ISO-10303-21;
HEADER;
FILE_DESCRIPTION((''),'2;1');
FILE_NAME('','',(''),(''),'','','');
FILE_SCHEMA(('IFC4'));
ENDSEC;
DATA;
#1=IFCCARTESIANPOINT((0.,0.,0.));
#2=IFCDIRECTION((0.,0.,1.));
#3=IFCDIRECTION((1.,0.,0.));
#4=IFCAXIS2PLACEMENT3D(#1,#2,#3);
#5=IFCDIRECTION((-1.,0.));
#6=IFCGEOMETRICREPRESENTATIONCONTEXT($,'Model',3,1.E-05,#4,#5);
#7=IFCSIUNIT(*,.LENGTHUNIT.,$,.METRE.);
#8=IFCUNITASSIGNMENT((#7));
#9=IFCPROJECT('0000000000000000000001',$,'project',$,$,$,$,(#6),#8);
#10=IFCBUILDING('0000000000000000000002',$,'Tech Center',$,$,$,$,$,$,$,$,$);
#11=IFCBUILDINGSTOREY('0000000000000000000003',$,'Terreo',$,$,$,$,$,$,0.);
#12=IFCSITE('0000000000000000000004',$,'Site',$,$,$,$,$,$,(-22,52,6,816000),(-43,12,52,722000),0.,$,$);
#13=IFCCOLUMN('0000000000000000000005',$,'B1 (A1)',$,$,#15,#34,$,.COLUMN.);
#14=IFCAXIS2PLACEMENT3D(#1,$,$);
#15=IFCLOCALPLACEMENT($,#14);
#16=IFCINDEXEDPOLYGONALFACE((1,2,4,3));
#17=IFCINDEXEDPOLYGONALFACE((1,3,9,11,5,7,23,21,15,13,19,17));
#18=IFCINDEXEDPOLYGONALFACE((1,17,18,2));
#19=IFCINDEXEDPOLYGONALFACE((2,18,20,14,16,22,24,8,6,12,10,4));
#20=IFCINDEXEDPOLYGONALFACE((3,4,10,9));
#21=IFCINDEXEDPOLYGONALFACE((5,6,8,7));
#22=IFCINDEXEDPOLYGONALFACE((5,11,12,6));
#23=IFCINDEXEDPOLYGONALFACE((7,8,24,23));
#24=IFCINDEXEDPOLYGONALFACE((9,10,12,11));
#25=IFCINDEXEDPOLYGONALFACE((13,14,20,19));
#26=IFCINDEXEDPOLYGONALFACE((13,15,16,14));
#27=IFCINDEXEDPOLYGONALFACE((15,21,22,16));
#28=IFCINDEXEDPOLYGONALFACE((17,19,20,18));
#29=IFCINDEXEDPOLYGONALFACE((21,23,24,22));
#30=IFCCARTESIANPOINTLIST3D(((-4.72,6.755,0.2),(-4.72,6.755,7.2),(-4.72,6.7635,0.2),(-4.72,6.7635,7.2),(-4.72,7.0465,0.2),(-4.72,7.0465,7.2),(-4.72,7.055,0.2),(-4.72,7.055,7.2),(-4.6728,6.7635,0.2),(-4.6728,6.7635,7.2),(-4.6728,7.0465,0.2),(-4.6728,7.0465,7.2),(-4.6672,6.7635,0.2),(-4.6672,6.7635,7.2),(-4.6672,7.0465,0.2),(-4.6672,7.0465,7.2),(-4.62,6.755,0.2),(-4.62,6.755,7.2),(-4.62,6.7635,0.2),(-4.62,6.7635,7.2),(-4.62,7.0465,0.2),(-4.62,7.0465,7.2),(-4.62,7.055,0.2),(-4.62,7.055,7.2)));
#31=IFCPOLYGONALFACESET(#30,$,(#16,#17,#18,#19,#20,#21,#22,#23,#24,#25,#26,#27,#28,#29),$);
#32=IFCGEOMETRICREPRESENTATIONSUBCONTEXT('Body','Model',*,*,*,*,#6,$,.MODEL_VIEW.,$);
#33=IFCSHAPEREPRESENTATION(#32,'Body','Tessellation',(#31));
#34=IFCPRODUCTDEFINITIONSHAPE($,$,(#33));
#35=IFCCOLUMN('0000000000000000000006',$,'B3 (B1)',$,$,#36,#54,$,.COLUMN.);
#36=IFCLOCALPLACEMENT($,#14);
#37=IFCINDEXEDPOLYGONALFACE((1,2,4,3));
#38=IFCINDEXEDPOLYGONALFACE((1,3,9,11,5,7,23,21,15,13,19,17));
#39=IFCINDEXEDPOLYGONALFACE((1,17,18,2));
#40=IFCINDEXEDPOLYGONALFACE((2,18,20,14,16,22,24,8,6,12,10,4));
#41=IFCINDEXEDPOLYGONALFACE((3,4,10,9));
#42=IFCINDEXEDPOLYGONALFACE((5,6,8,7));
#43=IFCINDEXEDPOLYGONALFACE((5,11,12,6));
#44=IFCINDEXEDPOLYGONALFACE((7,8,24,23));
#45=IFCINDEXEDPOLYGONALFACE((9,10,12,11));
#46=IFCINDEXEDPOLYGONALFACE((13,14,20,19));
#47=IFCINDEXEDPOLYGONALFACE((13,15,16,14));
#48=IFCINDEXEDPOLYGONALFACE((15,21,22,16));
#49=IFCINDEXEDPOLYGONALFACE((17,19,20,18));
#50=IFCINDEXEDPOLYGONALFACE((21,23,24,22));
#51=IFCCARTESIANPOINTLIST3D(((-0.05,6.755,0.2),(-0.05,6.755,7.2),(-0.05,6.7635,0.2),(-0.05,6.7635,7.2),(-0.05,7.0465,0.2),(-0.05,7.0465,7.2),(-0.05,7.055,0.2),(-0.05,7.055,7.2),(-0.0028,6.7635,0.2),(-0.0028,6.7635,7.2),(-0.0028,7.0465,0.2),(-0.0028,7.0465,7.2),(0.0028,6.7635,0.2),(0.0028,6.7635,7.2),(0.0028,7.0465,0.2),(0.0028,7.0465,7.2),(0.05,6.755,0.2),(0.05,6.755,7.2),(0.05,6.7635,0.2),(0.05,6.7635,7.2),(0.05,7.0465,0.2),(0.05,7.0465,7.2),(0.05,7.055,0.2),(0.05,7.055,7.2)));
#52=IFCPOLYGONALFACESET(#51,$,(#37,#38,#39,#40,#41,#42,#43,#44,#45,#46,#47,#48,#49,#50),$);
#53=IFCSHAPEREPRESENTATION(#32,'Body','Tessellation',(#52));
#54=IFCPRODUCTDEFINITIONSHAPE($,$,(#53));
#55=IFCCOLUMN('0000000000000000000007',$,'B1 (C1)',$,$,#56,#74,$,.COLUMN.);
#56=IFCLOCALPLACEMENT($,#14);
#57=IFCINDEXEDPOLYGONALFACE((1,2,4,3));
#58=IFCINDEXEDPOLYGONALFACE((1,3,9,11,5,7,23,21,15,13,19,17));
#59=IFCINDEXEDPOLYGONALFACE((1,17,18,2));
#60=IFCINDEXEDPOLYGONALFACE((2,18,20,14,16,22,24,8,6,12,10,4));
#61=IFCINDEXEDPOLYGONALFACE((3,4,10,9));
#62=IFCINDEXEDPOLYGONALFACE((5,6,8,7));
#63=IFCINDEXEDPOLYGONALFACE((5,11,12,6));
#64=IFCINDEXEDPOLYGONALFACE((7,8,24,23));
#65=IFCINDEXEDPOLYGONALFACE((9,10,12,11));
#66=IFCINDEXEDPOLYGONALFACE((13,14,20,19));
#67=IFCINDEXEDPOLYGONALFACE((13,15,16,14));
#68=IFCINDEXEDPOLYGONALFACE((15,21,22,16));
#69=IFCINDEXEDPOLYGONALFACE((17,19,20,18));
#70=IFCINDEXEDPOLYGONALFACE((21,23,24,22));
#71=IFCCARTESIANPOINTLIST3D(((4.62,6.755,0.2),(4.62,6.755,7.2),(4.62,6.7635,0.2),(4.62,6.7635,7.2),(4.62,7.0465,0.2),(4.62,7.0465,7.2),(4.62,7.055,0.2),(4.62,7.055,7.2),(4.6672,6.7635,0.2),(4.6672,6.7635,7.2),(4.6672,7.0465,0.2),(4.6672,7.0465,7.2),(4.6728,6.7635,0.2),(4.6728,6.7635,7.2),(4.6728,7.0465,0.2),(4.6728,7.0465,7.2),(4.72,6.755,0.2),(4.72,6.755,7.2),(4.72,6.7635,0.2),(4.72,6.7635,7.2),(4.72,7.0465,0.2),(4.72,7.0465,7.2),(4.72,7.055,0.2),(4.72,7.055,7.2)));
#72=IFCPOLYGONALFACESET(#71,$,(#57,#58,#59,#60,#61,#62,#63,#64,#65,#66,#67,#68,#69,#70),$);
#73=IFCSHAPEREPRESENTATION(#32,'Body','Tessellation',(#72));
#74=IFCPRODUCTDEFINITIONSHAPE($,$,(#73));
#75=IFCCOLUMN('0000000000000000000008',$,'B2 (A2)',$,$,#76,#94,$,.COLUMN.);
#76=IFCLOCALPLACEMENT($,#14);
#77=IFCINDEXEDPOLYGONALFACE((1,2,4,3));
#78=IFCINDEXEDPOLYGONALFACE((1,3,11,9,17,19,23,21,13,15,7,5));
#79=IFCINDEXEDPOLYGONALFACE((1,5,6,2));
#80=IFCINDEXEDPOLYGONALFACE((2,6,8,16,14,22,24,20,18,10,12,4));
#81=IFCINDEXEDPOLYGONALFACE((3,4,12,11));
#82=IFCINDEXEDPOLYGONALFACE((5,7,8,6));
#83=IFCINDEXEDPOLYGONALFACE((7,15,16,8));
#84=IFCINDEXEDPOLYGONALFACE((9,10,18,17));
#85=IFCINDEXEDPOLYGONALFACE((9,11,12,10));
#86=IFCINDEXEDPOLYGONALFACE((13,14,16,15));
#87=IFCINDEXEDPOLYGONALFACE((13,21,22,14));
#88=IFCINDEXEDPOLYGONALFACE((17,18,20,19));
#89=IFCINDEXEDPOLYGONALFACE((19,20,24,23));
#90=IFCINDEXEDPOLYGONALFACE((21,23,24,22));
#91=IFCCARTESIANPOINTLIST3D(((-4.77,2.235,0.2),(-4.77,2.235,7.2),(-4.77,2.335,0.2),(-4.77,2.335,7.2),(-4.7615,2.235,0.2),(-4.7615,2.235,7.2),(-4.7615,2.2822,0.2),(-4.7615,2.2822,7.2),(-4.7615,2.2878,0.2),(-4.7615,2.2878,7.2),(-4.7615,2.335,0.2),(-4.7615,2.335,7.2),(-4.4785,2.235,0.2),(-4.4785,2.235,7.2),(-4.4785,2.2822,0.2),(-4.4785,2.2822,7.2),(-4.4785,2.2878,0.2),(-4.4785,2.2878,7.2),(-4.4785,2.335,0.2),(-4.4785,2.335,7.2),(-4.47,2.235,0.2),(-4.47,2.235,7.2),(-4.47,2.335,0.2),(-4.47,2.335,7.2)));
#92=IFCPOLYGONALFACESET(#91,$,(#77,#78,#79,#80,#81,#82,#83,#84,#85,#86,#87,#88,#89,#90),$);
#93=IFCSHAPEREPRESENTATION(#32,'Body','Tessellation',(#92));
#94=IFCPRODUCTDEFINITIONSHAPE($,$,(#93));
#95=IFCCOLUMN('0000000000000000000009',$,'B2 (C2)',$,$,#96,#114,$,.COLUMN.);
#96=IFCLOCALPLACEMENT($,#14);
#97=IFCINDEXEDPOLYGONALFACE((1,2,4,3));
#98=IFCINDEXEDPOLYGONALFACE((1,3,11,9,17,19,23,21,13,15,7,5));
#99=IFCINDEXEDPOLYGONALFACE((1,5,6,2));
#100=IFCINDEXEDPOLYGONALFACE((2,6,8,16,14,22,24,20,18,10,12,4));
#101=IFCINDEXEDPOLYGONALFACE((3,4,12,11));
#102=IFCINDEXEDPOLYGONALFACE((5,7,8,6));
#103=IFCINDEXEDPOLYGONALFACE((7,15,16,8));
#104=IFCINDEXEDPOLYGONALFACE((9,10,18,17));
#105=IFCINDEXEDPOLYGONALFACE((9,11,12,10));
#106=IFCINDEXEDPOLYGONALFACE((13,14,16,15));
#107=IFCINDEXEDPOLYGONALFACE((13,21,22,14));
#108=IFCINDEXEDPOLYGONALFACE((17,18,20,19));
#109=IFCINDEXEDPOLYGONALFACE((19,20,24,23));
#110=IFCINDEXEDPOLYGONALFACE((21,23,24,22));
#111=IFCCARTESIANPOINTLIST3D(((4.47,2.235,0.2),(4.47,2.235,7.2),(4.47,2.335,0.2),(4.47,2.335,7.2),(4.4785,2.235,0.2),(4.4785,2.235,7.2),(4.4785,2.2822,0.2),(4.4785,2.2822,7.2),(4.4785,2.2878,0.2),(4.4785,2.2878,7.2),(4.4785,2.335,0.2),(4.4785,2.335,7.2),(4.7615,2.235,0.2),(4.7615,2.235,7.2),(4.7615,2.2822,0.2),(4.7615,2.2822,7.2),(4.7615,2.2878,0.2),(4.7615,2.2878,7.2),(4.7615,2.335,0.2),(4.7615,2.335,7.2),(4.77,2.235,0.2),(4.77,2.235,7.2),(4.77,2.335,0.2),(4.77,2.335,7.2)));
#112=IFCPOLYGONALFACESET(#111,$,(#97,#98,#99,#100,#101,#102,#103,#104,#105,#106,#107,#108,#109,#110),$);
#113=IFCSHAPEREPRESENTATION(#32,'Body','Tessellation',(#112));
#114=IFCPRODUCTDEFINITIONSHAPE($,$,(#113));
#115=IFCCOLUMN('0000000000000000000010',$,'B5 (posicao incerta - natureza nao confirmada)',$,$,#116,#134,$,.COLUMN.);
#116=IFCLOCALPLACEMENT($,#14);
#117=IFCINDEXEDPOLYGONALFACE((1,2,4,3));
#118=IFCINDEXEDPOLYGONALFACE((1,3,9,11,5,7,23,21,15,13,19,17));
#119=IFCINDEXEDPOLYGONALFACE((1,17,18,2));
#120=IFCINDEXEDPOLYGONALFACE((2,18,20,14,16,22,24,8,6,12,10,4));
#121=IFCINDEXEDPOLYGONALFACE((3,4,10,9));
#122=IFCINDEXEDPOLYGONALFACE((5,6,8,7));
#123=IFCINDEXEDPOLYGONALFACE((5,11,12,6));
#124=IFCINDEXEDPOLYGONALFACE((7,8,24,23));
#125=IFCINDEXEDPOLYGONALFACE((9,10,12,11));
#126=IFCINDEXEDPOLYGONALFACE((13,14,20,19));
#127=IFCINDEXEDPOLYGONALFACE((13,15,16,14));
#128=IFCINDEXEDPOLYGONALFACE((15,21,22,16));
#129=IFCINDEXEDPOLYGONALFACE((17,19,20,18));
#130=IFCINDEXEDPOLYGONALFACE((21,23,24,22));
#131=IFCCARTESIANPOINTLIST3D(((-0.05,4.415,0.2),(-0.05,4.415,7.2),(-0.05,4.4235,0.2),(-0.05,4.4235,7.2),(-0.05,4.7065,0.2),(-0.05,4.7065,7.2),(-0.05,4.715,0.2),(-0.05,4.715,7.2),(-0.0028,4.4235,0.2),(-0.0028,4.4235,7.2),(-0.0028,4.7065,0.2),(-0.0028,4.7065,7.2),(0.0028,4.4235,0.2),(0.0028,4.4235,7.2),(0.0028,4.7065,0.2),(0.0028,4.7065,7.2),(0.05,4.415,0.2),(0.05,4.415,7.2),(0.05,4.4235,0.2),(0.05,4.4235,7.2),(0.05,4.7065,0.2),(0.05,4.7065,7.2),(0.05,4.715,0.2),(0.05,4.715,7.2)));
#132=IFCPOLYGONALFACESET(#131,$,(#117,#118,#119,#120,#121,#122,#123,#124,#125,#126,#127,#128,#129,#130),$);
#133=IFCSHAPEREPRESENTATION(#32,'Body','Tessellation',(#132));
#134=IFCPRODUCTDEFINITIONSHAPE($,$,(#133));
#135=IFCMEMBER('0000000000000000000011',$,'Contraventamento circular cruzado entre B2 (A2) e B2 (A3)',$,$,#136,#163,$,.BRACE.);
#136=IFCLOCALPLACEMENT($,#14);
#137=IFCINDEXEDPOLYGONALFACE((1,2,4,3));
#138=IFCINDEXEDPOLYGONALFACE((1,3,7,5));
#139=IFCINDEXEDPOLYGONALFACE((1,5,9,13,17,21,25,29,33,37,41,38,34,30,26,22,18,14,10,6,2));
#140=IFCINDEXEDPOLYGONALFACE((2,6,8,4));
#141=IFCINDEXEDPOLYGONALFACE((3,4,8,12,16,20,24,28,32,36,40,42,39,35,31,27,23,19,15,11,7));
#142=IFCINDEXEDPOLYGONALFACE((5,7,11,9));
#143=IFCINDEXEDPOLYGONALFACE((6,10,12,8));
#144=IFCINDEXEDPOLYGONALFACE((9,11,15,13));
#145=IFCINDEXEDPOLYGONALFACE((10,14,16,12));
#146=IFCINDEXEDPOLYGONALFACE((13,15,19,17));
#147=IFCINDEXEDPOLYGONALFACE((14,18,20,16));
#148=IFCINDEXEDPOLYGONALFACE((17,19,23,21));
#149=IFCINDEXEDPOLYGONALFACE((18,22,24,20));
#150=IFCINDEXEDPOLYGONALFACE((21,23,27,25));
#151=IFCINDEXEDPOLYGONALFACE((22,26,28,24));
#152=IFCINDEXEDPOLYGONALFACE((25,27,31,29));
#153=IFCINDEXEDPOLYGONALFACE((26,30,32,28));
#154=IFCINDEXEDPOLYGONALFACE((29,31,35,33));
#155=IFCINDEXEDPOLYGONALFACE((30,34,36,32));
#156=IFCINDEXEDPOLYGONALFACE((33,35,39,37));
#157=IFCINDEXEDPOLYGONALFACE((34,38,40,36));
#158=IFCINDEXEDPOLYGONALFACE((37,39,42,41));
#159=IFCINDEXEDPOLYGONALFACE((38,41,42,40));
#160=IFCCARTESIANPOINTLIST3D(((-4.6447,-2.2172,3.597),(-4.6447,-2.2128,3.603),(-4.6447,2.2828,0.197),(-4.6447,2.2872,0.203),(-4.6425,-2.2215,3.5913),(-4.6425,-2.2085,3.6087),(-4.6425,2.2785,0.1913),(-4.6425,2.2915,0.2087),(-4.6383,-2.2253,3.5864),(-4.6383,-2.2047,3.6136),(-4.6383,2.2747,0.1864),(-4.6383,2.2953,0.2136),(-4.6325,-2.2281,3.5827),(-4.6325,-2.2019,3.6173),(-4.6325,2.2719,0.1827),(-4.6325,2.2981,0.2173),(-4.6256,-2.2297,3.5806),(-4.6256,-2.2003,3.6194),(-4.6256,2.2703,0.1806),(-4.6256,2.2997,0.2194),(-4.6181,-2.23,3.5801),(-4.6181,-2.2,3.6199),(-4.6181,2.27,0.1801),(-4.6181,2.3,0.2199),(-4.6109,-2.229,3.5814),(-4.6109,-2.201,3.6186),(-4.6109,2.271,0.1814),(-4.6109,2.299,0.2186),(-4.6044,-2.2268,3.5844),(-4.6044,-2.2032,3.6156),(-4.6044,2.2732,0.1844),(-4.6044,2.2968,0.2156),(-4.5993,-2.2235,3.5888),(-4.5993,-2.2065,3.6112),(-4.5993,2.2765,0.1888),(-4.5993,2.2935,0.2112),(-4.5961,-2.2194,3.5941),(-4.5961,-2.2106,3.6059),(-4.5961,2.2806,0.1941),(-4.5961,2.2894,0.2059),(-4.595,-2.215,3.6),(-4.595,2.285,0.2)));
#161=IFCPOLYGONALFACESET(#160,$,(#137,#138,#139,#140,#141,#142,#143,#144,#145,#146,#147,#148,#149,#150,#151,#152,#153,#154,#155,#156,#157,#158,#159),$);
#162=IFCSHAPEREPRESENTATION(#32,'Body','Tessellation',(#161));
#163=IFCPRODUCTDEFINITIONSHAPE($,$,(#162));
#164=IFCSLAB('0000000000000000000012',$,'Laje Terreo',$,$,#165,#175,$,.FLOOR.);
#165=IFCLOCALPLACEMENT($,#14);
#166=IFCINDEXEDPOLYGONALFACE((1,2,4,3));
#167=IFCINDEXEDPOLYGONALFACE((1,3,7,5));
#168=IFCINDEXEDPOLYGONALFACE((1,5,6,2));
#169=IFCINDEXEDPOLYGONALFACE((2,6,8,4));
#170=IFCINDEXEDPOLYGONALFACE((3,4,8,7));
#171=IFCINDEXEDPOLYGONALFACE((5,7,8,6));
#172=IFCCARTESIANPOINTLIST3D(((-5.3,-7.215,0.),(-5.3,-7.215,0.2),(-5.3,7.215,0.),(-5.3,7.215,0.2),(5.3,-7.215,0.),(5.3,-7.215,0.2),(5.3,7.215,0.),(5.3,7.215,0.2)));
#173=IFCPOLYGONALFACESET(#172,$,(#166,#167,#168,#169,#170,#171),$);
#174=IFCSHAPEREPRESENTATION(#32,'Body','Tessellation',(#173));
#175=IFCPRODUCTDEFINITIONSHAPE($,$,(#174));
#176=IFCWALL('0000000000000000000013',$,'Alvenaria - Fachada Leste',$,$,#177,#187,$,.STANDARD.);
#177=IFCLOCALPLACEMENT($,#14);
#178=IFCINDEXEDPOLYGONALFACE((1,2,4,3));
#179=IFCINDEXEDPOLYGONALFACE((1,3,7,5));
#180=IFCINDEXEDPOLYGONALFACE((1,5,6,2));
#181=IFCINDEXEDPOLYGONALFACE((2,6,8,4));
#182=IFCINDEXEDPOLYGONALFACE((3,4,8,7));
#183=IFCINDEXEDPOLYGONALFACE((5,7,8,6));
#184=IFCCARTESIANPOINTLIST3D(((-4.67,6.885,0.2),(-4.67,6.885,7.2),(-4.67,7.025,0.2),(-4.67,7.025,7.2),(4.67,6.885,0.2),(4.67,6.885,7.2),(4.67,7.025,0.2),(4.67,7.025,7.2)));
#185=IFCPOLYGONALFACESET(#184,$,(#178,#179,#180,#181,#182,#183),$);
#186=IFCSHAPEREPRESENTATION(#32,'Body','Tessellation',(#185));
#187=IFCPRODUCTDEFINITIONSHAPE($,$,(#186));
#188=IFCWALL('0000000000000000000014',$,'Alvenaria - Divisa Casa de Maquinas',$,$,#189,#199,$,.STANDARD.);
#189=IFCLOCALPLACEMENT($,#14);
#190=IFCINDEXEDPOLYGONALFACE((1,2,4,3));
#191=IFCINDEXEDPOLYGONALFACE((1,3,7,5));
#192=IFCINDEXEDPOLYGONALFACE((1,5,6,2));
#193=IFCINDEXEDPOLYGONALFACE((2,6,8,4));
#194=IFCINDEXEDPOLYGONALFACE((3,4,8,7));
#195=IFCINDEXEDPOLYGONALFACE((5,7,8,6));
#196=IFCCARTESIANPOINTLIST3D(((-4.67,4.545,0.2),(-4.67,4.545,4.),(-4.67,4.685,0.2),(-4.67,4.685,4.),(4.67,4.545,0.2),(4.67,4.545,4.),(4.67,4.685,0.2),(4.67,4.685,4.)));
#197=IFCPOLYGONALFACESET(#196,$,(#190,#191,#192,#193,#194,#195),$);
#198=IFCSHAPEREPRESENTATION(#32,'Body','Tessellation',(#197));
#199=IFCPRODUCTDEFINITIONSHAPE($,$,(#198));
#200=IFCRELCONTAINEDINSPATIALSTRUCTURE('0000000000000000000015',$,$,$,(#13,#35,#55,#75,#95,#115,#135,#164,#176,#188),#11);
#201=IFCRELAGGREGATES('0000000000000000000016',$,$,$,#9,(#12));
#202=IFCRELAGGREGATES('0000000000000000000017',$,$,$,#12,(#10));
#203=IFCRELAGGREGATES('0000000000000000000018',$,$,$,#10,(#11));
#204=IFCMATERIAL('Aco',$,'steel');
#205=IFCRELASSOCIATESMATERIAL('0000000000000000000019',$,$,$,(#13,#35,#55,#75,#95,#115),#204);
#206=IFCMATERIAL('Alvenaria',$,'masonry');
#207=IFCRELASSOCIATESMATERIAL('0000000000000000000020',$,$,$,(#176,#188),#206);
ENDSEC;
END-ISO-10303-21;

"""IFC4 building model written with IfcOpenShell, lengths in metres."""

from ifc_helpers import new_model, si_unit, direction, frame, origin_with_axes, place, context, subcontext, project, spatial, indexed_curve, rectangle, circle, i_section, outline, extrude, material, element, save


model = new_model("IFC4")

# Units and contexts
model_context = context("Model", 3, precision=1e-05, world=origin_with_axes(), true_north=direction((-1.0, 0.0)))
body_context = subcontext(model_context, "Body", "Model", "MODEL_VIEW")
ifc_project = project(units=[si_unit("LENGTHUNIT", "METRE")], contexts=[model_context])

# Site, building, storey
site = spatial("IfcSite", under=ifc_project, Name="Site", RefLatitude=(-22, 52, 6, 816000), RefLongitude=(-43, 12, 52, 722000), RefElevation=0.0)
building = spatial("IfcBuilding", under=site, Name="Tech Center")
storey = spatial("IfcBuildingStorey", under=building, Name="Terreo", Elevation=0.0)

# Columns
ifc_material_1 = material(Name="Aco", Category="steel")
for number, where, z_axis, x_axis, name in (
    (1, (-4.67, 6.905, 0.2), (0.0, 0.0, 1.0), (1.0, 0.0, 0.0), "B1 (A1)"),
    (2, (0.0, 6.905, 0.2), (0.0, 0.0, 1.0), (1.0, 0.0, 0.0), "B3 (B1)"),
    (3, (4.67, 6.905, 0.2), (0.0, 0.0, 1.0), (1.0, 0.0, 0.0), "B1 (C1)"),
    (4, (-4.62, 2.285, 0.2), (0.0, 0.0, 1.0), (0.0, 1.0, 0.0), "B2 (A2)"),
    (5, (4.62, 2.285, 0.2), (0.0, 0.0, 1.0), (0.0, 1.0, 0.0), "B2 (C2)"),
    (6, (0.0, 4.565, 0.2), (0.0, 0.0, 1.0), (1.0, 0.0, 0.0), "B5 (posicao incerta - natureza nao confirmada)"),
):
    element("IfcColumn", number, at=place(None, frame(where, z_axis=z_axis, x_axis=x_axis)), inside=storey, material=ifc_material_1, Name=name, PredefinedType="COLUMN", context=body_context, shape_type="SweptSolid", body=[
        extrude(i_section(OverallWidth=0.1, OverallDepth=0.3, WebThickness=0.0056, FlangeThickness=0.0085), origin_with_axes(), (0.0, 0.0, 1.0), 7.0),
    ])

# Member
member_placement = place(None, frame((-4.62, 2.285, 0.2), z_axis=(0.0, -0.797867, 0.602833), x_axis=(1.0, 0.0, 0.0)))
element("IfcMember", 7, at=member_placement, inside=storey, Name="Contraventamento circular cruzado entre B2 (A2) e B2 (A3)", PredefinedType="BRACE", context=body_context, shape_type="SweptSolid", body=[
    extrude(circle(Radius=0.025), origin_with_axes(), (0.0, 0.0, 1.0), 5.64),
])

# Slab
slab_placement = place(None, origin_with_axes())
element("IfcSlab", 8, at=slab_placement, inside=storey, Name="Laje Terreo", PredefinedType="FLOOR", context=body_context, shape_type="SweptSolid", body=[
    extrude(rectangle(XDim=10.6, YDim=14.43), origin_with_axes(), (0.0, 0.0, 1.0), 0.2),
])

# Walls
ifc_material_2 = material(Name="Alvenaria", Category="masonry")
wall_1_placement = place(None, frame((-4.67, 6.885, 0.2), z_axis=(0.0, 0.0, 1.0), x_axis=(1.0, 0.0, 0.0)))
element("IfcWall", 9, at=wall_1_placement, inside=storey, material=ifc_material_2, Name="Alvenaria - Fachada Leste", PredefinedType="STANDARD", context=body_context, shape_type="SweptSolid", body=[
    extrude(outline(indexed_curve([(0.0, 0.0), (0.0, 0.14), (9.34, 0.14), (9.34, 0.0), (0.0, 0.0)], self_intersect=False)), origin_with_axes(), (0.0, 0.0, 1.0), 7.0),
])
wall_2_placement = place(None, frame((-4.67, 4.545, 0.2), z_axis=(0.0, 0.0, 1.0), x_axis=(1.0, 0.0, 0.0)))
element("IfcWall", 10, at=wall_2_placement, inside=storey, material=ifc_material_2, Name="Alvenaria - Divisa Casa de Maquinas", PredefinedType="STANDARD", context=body_context, shape_type="SweptSolid", body=[
    extrude(outline(indexed_curve([(0.0, 0.0), (0.0, 0.14), (9.34, 0.14), (9.34, 0.0), (0.0, 0.0)], self_intersect=False)), origin_with_axes(), (0.0, 0.0, 1.0), 3.8),
])

save(model, "model.ifc")
